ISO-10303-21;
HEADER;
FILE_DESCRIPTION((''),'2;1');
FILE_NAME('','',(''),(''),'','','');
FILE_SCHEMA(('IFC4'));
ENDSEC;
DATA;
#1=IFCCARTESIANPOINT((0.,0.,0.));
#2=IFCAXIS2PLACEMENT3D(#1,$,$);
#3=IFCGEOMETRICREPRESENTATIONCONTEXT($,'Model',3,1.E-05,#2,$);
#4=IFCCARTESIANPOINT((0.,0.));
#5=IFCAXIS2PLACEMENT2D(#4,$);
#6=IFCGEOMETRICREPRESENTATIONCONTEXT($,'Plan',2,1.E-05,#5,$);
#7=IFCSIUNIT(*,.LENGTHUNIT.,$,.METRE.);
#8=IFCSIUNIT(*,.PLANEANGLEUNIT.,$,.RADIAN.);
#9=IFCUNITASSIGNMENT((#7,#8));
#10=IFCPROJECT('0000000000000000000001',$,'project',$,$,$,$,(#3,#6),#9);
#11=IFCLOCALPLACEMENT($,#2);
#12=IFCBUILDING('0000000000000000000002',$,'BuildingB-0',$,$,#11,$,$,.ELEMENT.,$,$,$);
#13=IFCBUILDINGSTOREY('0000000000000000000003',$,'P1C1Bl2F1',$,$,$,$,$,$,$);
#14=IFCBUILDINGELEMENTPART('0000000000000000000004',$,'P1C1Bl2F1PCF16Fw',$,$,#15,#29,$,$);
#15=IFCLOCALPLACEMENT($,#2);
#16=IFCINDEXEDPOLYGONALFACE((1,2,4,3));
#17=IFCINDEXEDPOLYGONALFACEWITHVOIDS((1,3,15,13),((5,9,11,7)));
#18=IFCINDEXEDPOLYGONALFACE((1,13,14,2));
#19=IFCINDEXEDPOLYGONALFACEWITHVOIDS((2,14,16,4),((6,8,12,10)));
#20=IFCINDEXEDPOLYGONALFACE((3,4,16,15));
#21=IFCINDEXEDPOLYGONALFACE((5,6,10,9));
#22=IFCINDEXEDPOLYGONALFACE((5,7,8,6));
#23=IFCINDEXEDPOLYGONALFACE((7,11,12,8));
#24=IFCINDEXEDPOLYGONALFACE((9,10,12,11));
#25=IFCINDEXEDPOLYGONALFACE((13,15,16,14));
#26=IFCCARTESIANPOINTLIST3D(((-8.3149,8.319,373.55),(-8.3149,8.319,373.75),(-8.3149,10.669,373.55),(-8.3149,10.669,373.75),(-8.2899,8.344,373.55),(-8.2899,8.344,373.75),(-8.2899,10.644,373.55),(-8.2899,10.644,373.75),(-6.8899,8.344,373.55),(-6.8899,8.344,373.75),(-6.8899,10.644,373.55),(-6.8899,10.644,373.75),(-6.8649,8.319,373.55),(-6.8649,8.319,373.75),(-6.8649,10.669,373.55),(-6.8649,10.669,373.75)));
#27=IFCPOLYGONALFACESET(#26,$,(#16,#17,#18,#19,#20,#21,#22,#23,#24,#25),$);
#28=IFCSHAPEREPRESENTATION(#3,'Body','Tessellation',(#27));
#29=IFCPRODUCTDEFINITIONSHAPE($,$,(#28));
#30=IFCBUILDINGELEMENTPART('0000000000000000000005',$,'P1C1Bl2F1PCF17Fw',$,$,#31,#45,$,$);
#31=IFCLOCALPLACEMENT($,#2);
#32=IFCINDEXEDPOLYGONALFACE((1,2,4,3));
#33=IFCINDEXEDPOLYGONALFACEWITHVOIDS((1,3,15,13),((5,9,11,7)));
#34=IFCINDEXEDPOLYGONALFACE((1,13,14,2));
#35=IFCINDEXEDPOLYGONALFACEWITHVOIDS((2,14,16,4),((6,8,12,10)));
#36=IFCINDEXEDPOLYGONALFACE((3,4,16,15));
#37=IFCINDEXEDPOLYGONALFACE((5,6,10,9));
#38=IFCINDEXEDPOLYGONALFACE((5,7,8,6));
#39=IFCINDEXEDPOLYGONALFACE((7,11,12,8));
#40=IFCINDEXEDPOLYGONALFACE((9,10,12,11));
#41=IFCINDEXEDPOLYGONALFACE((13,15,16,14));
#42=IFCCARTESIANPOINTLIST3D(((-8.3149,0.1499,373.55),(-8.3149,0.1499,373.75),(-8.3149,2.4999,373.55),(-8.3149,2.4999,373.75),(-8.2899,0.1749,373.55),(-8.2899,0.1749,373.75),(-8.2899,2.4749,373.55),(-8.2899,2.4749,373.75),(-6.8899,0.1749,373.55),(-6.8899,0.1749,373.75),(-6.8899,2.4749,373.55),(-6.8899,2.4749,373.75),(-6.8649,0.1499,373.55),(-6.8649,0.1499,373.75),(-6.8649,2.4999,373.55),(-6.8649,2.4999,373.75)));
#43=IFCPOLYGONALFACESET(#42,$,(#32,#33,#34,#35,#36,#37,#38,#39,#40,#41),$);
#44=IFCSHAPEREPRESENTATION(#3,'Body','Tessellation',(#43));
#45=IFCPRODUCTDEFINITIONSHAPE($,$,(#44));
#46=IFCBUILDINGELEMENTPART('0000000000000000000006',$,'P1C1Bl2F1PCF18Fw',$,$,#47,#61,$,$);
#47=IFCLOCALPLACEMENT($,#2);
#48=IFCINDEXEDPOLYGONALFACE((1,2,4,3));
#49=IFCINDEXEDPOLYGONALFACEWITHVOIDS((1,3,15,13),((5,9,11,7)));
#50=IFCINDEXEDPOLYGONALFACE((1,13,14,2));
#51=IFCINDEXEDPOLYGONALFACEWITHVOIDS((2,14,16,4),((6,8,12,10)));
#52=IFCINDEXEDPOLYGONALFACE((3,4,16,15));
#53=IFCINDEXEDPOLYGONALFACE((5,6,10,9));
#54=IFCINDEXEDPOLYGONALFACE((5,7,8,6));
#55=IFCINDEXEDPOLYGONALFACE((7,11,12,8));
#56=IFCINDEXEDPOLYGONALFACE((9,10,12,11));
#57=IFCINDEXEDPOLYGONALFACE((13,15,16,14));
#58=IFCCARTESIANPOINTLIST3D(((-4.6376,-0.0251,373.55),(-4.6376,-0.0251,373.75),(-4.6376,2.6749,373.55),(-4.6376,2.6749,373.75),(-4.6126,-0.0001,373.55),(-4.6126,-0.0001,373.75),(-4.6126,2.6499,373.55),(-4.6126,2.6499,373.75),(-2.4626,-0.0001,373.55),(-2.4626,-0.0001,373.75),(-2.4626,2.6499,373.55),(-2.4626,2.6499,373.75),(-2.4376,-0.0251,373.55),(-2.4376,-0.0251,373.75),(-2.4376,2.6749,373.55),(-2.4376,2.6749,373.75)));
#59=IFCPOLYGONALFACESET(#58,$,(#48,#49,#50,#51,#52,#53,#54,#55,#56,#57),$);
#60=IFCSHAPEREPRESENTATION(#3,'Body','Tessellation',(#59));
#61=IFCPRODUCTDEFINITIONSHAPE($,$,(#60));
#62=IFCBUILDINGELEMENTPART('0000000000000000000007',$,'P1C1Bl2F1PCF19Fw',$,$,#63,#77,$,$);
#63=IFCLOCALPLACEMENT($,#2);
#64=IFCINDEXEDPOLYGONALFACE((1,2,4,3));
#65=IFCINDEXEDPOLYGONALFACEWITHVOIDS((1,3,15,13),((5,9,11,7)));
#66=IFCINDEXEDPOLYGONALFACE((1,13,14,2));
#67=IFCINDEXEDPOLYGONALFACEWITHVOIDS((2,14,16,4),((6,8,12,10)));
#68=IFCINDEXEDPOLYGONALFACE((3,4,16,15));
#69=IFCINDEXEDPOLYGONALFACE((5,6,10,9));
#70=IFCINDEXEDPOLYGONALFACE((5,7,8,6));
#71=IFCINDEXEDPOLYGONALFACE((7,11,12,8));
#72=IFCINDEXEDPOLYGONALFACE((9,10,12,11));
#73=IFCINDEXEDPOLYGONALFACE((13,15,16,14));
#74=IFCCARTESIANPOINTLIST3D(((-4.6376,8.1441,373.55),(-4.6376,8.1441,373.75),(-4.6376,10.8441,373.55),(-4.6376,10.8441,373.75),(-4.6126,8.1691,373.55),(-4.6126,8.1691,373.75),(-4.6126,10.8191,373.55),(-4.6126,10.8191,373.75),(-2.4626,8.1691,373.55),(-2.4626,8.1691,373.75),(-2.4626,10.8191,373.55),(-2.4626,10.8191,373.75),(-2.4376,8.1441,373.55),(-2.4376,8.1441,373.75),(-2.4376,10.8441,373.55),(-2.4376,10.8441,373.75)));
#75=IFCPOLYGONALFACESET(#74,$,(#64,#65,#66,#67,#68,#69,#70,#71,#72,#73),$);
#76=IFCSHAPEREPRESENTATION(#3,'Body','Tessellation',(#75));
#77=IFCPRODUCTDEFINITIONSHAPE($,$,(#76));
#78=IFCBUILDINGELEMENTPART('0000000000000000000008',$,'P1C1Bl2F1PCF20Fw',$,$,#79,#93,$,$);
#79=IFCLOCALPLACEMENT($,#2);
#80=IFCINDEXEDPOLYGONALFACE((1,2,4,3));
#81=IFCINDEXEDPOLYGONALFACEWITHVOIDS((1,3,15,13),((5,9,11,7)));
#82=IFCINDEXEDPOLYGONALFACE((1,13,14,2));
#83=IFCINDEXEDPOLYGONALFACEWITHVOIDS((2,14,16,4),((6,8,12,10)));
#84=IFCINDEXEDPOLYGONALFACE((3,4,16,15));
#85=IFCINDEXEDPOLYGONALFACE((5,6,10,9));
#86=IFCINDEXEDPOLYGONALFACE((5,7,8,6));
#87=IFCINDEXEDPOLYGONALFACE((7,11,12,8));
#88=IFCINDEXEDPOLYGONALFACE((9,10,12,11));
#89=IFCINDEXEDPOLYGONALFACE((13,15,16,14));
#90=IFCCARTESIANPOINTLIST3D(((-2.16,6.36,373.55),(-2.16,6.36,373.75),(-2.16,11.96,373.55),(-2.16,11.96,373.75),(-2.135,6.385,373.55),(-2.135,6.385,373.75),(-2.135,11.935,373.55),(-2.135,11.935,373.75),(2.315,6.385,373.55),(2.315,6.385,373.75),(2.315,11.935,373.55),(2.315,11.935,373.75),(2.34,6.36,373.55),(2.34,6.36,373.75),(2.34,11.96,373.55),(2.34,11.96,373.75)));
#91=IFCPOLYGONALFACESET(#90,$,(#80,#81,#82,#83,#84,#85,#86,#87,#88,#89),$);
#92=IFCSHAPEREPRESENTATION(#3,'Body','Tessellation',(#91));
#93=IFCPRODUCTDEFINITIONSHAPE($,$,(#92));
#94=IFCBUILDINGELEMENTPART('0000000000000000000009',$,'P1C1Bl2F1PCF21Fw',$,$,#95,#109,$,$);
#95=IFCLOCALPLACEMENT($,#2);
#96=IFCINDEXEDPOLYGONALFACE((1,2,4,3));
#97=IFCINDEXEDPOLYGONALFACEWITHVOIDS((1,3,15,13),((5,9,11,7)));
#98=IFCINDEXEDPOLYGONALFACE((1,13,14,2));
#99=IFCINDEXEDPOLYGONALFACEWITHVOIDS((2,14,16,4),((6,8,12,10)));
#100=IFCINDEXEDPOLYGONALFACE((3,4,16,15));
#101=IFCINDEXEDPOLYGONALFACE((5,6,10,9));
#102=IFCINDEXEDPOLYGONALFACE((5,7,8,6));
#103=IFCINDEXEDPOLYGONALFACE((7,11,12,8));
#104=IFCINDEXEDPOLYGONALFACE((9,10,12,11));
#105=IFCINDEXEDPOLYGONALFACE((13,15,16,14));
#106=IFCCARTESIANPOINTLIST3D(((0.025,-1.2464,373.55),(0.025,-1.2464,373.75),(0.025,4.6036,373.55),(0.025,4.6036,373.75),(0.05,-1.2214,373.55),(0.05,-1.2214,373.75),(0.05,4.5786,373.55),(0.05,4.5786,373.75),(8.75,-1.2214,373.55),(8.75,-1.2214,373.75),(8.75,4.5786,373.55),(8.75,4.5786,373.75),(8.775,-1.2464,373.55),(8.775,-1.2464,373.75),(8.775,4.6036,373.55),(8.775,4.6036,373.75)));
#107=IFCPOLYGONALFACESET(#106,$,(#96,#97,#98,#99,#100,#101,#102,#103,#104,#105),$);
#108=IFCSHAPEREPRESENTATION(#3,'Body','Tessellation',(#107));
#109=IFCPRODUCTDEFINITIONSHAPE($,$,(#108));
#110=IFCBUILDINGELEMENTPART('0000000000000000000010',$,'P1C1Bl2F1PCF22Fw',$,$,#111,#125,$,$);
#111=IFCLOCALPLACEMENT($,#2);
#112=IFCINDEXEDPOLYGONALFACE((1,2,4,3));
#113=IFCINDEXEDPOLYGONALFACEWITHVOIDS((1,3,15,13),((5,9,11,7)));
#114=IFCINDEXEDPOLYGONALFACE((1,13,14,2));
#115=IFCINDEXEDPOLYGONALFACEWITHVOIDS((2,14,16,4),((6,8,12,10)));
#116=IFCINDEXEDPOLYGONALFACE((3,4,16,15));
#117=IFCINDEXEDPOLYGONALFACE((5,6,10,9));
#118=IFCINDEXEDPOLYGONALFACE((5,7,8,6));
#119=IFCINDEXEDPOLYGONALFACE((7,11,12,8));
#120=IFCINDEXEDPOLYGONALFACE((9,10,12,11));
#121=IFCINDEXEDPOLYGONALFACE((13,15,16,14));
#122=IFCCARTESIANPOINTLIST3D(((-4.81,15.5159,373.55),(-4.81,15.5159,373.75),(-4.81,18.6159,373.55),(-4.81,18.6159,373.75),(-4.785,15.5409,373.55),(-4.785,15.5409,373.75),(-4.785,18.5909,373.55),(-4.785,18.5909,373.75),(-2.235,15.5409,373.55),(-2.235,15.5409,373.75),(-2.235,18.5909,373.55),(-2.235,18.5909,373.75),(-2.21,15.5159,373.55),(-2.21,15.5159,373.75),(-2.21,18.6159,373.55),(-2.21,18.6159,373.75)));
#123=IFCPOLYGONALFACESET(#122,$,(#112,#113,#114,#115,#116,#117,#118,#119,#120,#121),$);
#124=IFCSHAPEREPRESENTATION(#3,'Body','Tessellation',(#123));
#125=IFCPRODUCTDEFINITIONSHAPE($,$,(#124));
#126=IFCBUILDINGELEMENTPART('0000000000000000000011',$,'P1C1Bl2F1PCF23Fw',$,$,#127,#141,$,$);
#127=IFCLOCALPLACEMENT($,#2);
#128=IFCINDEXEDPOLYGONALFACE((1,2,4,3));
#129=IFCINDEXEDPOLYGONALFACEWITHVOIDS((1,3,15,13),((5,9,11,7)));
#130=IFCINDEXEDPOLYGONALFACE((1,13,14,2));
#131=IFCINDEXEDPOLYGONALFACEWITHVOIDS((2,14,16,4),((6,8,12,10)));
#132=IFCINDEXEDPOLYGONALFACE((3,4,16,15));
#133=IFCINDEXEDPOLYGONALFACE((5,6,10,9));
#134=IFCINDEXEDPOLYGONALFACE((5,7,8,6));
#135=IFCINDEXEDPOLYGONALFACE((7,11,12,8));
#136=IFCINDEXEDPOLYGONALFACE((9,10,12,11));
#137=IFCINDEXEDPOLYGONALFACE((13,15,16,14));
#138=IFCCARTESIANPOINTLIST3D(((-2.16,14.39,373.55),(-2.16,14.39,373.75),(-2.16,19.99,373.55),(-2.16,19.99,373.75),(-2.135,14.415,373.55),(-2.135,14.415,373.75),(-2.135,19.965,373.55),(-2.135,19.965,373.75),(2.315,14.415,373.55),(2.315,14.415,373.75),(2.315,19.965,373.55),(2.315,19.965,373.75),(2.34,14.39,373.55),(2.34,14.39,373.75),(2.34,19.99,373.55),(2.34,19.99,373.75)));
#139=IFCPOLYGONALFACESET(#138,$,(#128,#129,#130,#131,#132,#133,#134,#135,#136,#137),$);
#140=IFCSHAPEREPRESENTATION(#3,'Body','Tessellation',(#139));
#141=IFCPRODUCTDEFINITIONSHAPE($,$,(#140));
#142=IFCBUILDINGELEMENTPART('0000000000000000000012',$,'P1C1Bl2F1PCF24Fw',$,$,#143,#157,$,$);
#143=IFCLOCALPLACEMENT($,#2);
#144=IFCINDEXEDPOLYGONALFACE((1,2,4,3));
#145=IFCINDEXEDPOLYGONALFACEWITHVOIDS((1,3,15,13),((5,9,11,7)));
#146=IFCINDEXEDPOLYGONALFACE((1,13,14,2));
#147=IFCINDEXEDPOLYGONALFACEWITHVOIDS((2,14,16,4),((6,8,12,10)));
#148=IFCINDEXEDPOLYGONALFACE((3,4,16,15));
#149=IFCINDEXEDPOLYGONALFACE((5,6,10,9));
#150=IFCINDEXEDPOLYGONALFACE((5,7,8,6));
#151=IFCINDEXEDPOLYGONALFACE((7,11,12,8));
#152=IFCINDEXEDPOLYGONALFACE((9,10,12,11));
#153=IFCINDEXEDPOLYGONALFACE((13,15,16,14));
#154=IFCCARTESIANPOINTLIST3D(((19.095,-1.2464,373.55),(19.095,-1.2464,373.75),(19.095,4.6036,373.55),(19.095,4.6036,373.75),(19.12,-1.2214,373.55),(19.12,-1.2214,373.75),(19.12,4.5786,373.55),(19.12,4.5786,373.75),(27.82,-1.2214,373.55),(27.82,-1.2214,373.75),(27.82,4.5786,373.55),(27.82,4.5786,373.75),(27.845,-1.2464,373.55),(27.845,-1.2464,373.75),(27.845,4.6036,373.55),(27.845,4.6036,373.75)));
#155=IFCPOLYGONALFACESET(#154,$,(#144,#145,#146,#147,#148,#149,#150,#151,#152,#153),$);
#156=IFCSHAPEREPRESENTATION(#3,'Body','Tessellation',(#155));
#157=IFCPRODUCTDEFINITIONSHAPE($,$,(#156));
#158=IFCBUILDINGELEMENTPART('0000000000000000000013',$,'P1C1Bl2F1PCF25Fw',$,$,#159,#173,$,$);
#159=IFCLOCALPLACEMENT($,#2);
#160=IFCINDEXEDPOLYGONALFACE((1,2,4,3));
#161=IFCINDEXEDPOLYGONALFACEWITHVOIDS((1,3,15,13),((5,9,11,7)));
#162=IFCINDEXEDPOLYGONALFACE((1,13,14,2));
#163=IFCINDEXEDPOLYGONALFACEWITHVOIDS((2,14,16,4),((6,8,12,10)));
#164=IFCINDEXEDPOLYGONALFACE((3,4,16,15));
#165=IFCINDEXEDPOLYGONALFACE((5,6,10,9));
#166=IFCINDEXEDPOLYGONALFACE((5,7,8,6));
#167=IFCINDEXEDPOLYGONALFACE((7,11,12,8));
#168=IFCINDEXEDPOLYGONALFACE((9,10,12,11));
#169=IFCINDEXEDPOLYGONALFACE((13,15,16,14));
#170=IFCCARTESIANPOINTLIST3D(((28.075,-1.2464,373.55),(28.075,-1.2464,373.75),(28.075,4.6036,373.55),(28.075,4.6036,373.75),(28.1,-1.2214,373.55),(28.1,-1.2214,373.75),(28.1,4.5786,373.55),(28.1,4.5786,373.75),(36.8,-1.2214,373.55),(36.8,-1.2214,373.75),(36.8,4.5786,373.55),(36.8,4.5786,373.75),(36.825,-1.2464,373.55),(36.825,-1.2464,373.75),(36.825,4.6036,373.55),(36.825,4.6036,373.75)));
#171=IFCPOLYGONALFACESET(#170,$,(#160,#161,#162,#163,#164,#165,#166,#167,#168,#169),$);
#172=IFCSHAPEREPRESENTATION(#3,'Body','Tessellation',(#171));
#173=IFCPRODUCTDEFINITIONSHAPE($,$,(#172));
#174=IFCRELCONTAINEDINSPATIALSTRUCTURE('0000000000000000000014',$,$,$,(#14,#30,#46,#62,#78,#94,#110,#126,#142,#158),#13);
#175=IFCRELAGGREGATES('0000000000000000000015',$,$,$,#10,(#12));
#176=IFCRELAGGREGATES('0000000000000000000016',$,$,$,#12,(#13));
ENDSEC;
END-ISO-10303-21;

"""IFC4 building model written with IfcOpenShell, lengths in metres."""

from ifc_helpers import new_model, si_unit, origin, origin_2d, place, context, project, spatial, polyline, outline, extrude, element, save


model = new_model("IFC4")

# Units and contexts
model_context = context("Model", 3, precision=1e-05, world=origin())
plan_context = context("Plan", 2, precision=1e-05, world=origin_2d())
ifc_project = project(units=[si_unit("LENGTHUNIT", "METRE"), si_unit("PLANEANGLEUNIT", "RADIAN")], contexts=[model_context, plan_context])

# Building, storey
building_placement = place(None, origin())
building = spatial("IfcBuilding", under=ifc_project, at=building_placement, Name="BuildingB-0", CompositionType="ELEMENT")
storey = spatial("IfcBuildingStorey", under=building, Name="P1C1Bl2F1")

# Building element parts, openings
building_element_part_1 = element("IfcBuildingElementPart", 1, inside=storey, Name="P1C1Bl2F1PCF16Fw", context=model_context, shape_type="SweptSolid", body=[
    extrude(outline(polyline([(-8.3149, 8.319, 373.55), (-6.8649, 8.319, 373.55), (-6.8649, 10.669, 373.55), (-8.3149, 10.669, 373.55), (-8.3149, 8.319, 373.55)])), None, (0.0, 0.0, 1.0), 0.2),
])
element("IfcOpeningElement", 2, inside=storey, cuts=building_element_part_1, context=model_context, shape_type="SweptSolid", body=[
    extrude(outline(polyline([(-8.2899, 8.344, 373.55), (-6.8899, 8.344, 373.55), (-6.8899, 10.644, 373.55), (-8.2899, 10.644, 373.55), (-8.2899, 8.344, 373.55)])), None, (0.0, 0.0, 1.0), 0.2),
])
building_element_part_2 = element("IfcBuildingElementPart", 3, inside=storey, Name="P1C1Bl2F1PCF17Fw", context=model_context, shape_type="SweptSolid", body=[
    extrude(outline(polyline([(-8.3149, 0.1499, 373.55), (-6.8649, 0.1499, 373.55), (-6.8649, 2.4999, 373.55), (-8.3149, 2.4999, 373.55), (-8.3149, 0.1499, 373.55)])), None, (0.0, 0.0, 1.0), 0.2),
])
element("IfcOpeningElement", 4, inside=storey, cuts=building_element_part_2, context=model_context, shape_type="SweptSolid", body=[
    extrude(outline(polyline([(-8.2899, 0.1749, 373.55), (-6.8899, 0.1749, 373.55), (-6.8899, 2.4749, 373.55), (-8.2899, 2.4749, 373.55), (-8.2899, 0.1749, 373.55)])), None, (0.0, 0.0, 1.0), 0.2),
])
building_element_part_3 = element("IfcBuildingElementPart", 5, inside=storey, Name="P1C1Bl2F1PCF18Fw", context=model_context, shape_type="SweptSolid", body=[
    extrude(outline(polyline([(-4.6376, -0.0251, 373.55), (-2.4376, -0.0251, 373.55), (-2.4376, 2.6749, 373.55), (-4.6376, 2.6749, 373.55), (-4.6376, -0.0251, 373.55)])), None, (0.0, 0.0, 1.0), 0.2),
])
element("IfcOpeningElement", 6, inside=storey, cuts=building_element_part_3, context=model_context, shape_type="SweptSolid", body=[
    extrude(outline(polyline([(-4.6126, -0.0001, 373.55), (-2.4626, -0.0001, 373.55), (-2.4626, 2.6499, 373.55), (-4.6126, 2.6499, 373.55), (-4.6126, -0.0001, 373.55)])), None, (0.0, 0.0, 1.0), 0.2),
])
building_element_part_4 = element("IfcBuildingElementPart", 7, inside=storey, Name="P1C1Bl2F1PCF19Fw", context=model_context, shape_type="SweptSolid", body=[
    extrude(outline(polyline([(-4.6376, 8.1441, 373.55), (-2.4376, 8.1441, 373.55), (-2.4376, 10.8441, 373.55), (-4.6376, 10.8441, 373.55), (-4.6376, 8.1441, 373.55)])), None, (0.0, 0.0, 1.0), 0.2),
])
element("IfcOpeningElement", 8, inside=storey, cuts=building_element_part_4, context=model_context, shape_type="SweptSolid", body=[
    extrude(outline(polyline([(-4.6126, 8.1691, 373.55), (-2.4626, 8.1691, 373.55), (-2.4626, 10.8191, 373.55), (-4.6126, 10.8191, 373.55), (-4.6126, 8.1691, 373.55)])), None, (0.0, 0.0, 1.0), 0.2),
])
building_element_part_5 = element("IfcBuildingElementPart", 9, inside=storey, Name="P1C1Bl2F1PCF20Fw", context=model_context, shape_type="SweptSolid", body=[
    extrude(outline(polyline([(-2.16, 6.36, 373.55), (2.34, 6.36, 373.55), (2.34, 11.96, 373.55), (-2.16, 11.96, 373.55), (-2.16, 6.36, 373.55)])), None, (0.0, 0.0, 1.0), 0.2),
])
element("IfcOpeningElement", 10, inside=storey, cuts=building_element_part_5, context=model_context, shape_type="SweptSolid", body=[
    extrude(outline(polyline([(-2.135, 6.385, 373.55), (2.315, 6.385, 373.55), (2.315, 11.935, 373.55), (-2.135, 11.935, 373.55), (-2.135, 6.385, 373.55)])), None, (0.0, 0.0, 1.0), 0.2),
])
building_element_part_6 = element("IfcBuildingElementPart", 11, inside=storey, Name="P1C1Bl2F1PCF21Fw", context=model_context, shape_type="SweptSolid", body=[
    extrude(outline(polyline([(0.025, -1.2464, 373.55), (8.775, -1.2464, 373.55), (8.775, 4.6036, 373.55), (0.025, 4.6036, 373.55), (0.025, -1.2464, 373.55)])), None, (0.0, 0.0, 1.0), 0.2),
])
element("IfcOpeningElement", 12, inside=storey, cuts=building_element_part_6, context=model_context, shape_type="SweptSolid", body=[
    extrude(outline(polyline([(0.05, -1.2214, 373.55), (8.75, -1.2214, 373.55), (8.75, 4.5786, 373.55), (0.05, 4.5786, 373.55), (0.05, -1.2214, 373.55)])), None, (0.0, 0.0, 1.0), 0.2),
])
building_element_part_7 = element("IfcBuildingElementPart", 13, inside=storey, Name="P1C1Bl2F1PCF22Fw", context=model_context, shape_type="SweptSolid", body=[
    extrude(outline(polyline([(-4.81, 15.5159, 373.55), (-2.21, 15.5159, 373.55), (-2.21, 18.6159, 373.55), (-4.81, 18.6159, 373.55), (-4.81, 15.5159, 373.55)])), None, (0.0, 0.0, 1.0), 0.2),
])
element("IfcOpeningElement", 14, inside=storey, cuts=building_element_part_7, context=model_context, shape_type="SweptSolid", body=[
    extrude(outline(polyline([(-4.785, 15.5409, 373.55), (-2.235, 15.5409, 373.55), (-2.235, 18.5909, 373.55), (-4.785, 18.5909, 373.55), (-4.785, 15.5409, 373.55)])), None, (0.0, 0.0, 1.0), 0.2),
])
building_element_part_8 = element("IfcBuildingElementPart", 15, inside=storey, Name="P1C1Bl2F1PCF23Fw", context=model_context, shape_type="SweptSolid", body=[
    extrude(outline(polyline([(-2.16, 14.39, 373.55), (2.34, 14.39, 373.55), (2.34, 19.99, 373.55), (-2.16, 19.99, 373.55), (-2.16, 14.39, 373.55)])), None, (0.0, 0.0, 1.0), 0.2),
])
element("IfcOpeningElement", 16, inside=storey, cuts=building_element_part_8, context=model_context, shape_type="SweptSolid", body=[
    extrude(outline(polyline([(-2.135, 14.415, 373.55), (2.315, 14.415, 373.55), (2.315, 19.965, 373.55), (-2.135, 19.965, 373.55), (-2.135, 14.415, 373.55)])), None, (0.0, 0.0, 1.0), 0.2),
])
building_element_part_9 = element("IfcBuildingElementPart", 17, inside=storey, Name="P1C1Bl2F1PCF24Fw", context=model_context, shape_type="SweptSolid", body=[
    extrude(outline(polyline([(19.095, -1.2464, 373.55), (27.845, -1.2464, 373.55), (27.845, 4.6036, 373.55), (19.095, 4.6036, 373.55), (19.095, -1.2464, 373.55)])), None, (0.0, 0.0, 1.0), 0.2),
])
element("IfcOpeningElement", 18, inside=storey, cuts=building_element_part_9, context=model_context, shape_type="SweptSolid", body=[
    extrude(outline(polyline([(19.12, -1.2214, 373.55), (27.82, -1.2214, 373.55), (27.82, 4.5786, 373.55), (19.12, 4.5786, 373.55), (19.12, -1.2214, 373.55)])), None, (0.0, 0.0, 1.0), 0.2),
])
building_element_part_10 = element("IfcBuildingElementPart", 19, inside=storey, Name="P1C1Bl2F1PCF25Fw", context=model_context, shape_type="SweptSolid", body=[
    extrude(outline(polyline([(28.075, -1.2464, 373.55), (36.825, -1.2464, 373.55), (36.825, 4.6036, 373.55), (28.075, 4.6036, 373.55), (28.075, -1.2464, 373.55)])), None, (0.0, 0.0, 1.0), 0.2),
])
element("IfcOpeningElement", 20, inside=storey, cuts=building_element_part_10, context=model_context, shape_type="SweptSolid", body=[
    extrude(outline(polyline([(28.1, -1.2214, 373.55), (36.8, -1.2214, 373.55), (36.8, 4.5786, 373.55), (28.1, 4.5786, 373.55), (28.1, -1.2214, 373.55)])), None, (0.0, 0.0, 1.0), 0.2),
])

save(model, "model.ifc")
